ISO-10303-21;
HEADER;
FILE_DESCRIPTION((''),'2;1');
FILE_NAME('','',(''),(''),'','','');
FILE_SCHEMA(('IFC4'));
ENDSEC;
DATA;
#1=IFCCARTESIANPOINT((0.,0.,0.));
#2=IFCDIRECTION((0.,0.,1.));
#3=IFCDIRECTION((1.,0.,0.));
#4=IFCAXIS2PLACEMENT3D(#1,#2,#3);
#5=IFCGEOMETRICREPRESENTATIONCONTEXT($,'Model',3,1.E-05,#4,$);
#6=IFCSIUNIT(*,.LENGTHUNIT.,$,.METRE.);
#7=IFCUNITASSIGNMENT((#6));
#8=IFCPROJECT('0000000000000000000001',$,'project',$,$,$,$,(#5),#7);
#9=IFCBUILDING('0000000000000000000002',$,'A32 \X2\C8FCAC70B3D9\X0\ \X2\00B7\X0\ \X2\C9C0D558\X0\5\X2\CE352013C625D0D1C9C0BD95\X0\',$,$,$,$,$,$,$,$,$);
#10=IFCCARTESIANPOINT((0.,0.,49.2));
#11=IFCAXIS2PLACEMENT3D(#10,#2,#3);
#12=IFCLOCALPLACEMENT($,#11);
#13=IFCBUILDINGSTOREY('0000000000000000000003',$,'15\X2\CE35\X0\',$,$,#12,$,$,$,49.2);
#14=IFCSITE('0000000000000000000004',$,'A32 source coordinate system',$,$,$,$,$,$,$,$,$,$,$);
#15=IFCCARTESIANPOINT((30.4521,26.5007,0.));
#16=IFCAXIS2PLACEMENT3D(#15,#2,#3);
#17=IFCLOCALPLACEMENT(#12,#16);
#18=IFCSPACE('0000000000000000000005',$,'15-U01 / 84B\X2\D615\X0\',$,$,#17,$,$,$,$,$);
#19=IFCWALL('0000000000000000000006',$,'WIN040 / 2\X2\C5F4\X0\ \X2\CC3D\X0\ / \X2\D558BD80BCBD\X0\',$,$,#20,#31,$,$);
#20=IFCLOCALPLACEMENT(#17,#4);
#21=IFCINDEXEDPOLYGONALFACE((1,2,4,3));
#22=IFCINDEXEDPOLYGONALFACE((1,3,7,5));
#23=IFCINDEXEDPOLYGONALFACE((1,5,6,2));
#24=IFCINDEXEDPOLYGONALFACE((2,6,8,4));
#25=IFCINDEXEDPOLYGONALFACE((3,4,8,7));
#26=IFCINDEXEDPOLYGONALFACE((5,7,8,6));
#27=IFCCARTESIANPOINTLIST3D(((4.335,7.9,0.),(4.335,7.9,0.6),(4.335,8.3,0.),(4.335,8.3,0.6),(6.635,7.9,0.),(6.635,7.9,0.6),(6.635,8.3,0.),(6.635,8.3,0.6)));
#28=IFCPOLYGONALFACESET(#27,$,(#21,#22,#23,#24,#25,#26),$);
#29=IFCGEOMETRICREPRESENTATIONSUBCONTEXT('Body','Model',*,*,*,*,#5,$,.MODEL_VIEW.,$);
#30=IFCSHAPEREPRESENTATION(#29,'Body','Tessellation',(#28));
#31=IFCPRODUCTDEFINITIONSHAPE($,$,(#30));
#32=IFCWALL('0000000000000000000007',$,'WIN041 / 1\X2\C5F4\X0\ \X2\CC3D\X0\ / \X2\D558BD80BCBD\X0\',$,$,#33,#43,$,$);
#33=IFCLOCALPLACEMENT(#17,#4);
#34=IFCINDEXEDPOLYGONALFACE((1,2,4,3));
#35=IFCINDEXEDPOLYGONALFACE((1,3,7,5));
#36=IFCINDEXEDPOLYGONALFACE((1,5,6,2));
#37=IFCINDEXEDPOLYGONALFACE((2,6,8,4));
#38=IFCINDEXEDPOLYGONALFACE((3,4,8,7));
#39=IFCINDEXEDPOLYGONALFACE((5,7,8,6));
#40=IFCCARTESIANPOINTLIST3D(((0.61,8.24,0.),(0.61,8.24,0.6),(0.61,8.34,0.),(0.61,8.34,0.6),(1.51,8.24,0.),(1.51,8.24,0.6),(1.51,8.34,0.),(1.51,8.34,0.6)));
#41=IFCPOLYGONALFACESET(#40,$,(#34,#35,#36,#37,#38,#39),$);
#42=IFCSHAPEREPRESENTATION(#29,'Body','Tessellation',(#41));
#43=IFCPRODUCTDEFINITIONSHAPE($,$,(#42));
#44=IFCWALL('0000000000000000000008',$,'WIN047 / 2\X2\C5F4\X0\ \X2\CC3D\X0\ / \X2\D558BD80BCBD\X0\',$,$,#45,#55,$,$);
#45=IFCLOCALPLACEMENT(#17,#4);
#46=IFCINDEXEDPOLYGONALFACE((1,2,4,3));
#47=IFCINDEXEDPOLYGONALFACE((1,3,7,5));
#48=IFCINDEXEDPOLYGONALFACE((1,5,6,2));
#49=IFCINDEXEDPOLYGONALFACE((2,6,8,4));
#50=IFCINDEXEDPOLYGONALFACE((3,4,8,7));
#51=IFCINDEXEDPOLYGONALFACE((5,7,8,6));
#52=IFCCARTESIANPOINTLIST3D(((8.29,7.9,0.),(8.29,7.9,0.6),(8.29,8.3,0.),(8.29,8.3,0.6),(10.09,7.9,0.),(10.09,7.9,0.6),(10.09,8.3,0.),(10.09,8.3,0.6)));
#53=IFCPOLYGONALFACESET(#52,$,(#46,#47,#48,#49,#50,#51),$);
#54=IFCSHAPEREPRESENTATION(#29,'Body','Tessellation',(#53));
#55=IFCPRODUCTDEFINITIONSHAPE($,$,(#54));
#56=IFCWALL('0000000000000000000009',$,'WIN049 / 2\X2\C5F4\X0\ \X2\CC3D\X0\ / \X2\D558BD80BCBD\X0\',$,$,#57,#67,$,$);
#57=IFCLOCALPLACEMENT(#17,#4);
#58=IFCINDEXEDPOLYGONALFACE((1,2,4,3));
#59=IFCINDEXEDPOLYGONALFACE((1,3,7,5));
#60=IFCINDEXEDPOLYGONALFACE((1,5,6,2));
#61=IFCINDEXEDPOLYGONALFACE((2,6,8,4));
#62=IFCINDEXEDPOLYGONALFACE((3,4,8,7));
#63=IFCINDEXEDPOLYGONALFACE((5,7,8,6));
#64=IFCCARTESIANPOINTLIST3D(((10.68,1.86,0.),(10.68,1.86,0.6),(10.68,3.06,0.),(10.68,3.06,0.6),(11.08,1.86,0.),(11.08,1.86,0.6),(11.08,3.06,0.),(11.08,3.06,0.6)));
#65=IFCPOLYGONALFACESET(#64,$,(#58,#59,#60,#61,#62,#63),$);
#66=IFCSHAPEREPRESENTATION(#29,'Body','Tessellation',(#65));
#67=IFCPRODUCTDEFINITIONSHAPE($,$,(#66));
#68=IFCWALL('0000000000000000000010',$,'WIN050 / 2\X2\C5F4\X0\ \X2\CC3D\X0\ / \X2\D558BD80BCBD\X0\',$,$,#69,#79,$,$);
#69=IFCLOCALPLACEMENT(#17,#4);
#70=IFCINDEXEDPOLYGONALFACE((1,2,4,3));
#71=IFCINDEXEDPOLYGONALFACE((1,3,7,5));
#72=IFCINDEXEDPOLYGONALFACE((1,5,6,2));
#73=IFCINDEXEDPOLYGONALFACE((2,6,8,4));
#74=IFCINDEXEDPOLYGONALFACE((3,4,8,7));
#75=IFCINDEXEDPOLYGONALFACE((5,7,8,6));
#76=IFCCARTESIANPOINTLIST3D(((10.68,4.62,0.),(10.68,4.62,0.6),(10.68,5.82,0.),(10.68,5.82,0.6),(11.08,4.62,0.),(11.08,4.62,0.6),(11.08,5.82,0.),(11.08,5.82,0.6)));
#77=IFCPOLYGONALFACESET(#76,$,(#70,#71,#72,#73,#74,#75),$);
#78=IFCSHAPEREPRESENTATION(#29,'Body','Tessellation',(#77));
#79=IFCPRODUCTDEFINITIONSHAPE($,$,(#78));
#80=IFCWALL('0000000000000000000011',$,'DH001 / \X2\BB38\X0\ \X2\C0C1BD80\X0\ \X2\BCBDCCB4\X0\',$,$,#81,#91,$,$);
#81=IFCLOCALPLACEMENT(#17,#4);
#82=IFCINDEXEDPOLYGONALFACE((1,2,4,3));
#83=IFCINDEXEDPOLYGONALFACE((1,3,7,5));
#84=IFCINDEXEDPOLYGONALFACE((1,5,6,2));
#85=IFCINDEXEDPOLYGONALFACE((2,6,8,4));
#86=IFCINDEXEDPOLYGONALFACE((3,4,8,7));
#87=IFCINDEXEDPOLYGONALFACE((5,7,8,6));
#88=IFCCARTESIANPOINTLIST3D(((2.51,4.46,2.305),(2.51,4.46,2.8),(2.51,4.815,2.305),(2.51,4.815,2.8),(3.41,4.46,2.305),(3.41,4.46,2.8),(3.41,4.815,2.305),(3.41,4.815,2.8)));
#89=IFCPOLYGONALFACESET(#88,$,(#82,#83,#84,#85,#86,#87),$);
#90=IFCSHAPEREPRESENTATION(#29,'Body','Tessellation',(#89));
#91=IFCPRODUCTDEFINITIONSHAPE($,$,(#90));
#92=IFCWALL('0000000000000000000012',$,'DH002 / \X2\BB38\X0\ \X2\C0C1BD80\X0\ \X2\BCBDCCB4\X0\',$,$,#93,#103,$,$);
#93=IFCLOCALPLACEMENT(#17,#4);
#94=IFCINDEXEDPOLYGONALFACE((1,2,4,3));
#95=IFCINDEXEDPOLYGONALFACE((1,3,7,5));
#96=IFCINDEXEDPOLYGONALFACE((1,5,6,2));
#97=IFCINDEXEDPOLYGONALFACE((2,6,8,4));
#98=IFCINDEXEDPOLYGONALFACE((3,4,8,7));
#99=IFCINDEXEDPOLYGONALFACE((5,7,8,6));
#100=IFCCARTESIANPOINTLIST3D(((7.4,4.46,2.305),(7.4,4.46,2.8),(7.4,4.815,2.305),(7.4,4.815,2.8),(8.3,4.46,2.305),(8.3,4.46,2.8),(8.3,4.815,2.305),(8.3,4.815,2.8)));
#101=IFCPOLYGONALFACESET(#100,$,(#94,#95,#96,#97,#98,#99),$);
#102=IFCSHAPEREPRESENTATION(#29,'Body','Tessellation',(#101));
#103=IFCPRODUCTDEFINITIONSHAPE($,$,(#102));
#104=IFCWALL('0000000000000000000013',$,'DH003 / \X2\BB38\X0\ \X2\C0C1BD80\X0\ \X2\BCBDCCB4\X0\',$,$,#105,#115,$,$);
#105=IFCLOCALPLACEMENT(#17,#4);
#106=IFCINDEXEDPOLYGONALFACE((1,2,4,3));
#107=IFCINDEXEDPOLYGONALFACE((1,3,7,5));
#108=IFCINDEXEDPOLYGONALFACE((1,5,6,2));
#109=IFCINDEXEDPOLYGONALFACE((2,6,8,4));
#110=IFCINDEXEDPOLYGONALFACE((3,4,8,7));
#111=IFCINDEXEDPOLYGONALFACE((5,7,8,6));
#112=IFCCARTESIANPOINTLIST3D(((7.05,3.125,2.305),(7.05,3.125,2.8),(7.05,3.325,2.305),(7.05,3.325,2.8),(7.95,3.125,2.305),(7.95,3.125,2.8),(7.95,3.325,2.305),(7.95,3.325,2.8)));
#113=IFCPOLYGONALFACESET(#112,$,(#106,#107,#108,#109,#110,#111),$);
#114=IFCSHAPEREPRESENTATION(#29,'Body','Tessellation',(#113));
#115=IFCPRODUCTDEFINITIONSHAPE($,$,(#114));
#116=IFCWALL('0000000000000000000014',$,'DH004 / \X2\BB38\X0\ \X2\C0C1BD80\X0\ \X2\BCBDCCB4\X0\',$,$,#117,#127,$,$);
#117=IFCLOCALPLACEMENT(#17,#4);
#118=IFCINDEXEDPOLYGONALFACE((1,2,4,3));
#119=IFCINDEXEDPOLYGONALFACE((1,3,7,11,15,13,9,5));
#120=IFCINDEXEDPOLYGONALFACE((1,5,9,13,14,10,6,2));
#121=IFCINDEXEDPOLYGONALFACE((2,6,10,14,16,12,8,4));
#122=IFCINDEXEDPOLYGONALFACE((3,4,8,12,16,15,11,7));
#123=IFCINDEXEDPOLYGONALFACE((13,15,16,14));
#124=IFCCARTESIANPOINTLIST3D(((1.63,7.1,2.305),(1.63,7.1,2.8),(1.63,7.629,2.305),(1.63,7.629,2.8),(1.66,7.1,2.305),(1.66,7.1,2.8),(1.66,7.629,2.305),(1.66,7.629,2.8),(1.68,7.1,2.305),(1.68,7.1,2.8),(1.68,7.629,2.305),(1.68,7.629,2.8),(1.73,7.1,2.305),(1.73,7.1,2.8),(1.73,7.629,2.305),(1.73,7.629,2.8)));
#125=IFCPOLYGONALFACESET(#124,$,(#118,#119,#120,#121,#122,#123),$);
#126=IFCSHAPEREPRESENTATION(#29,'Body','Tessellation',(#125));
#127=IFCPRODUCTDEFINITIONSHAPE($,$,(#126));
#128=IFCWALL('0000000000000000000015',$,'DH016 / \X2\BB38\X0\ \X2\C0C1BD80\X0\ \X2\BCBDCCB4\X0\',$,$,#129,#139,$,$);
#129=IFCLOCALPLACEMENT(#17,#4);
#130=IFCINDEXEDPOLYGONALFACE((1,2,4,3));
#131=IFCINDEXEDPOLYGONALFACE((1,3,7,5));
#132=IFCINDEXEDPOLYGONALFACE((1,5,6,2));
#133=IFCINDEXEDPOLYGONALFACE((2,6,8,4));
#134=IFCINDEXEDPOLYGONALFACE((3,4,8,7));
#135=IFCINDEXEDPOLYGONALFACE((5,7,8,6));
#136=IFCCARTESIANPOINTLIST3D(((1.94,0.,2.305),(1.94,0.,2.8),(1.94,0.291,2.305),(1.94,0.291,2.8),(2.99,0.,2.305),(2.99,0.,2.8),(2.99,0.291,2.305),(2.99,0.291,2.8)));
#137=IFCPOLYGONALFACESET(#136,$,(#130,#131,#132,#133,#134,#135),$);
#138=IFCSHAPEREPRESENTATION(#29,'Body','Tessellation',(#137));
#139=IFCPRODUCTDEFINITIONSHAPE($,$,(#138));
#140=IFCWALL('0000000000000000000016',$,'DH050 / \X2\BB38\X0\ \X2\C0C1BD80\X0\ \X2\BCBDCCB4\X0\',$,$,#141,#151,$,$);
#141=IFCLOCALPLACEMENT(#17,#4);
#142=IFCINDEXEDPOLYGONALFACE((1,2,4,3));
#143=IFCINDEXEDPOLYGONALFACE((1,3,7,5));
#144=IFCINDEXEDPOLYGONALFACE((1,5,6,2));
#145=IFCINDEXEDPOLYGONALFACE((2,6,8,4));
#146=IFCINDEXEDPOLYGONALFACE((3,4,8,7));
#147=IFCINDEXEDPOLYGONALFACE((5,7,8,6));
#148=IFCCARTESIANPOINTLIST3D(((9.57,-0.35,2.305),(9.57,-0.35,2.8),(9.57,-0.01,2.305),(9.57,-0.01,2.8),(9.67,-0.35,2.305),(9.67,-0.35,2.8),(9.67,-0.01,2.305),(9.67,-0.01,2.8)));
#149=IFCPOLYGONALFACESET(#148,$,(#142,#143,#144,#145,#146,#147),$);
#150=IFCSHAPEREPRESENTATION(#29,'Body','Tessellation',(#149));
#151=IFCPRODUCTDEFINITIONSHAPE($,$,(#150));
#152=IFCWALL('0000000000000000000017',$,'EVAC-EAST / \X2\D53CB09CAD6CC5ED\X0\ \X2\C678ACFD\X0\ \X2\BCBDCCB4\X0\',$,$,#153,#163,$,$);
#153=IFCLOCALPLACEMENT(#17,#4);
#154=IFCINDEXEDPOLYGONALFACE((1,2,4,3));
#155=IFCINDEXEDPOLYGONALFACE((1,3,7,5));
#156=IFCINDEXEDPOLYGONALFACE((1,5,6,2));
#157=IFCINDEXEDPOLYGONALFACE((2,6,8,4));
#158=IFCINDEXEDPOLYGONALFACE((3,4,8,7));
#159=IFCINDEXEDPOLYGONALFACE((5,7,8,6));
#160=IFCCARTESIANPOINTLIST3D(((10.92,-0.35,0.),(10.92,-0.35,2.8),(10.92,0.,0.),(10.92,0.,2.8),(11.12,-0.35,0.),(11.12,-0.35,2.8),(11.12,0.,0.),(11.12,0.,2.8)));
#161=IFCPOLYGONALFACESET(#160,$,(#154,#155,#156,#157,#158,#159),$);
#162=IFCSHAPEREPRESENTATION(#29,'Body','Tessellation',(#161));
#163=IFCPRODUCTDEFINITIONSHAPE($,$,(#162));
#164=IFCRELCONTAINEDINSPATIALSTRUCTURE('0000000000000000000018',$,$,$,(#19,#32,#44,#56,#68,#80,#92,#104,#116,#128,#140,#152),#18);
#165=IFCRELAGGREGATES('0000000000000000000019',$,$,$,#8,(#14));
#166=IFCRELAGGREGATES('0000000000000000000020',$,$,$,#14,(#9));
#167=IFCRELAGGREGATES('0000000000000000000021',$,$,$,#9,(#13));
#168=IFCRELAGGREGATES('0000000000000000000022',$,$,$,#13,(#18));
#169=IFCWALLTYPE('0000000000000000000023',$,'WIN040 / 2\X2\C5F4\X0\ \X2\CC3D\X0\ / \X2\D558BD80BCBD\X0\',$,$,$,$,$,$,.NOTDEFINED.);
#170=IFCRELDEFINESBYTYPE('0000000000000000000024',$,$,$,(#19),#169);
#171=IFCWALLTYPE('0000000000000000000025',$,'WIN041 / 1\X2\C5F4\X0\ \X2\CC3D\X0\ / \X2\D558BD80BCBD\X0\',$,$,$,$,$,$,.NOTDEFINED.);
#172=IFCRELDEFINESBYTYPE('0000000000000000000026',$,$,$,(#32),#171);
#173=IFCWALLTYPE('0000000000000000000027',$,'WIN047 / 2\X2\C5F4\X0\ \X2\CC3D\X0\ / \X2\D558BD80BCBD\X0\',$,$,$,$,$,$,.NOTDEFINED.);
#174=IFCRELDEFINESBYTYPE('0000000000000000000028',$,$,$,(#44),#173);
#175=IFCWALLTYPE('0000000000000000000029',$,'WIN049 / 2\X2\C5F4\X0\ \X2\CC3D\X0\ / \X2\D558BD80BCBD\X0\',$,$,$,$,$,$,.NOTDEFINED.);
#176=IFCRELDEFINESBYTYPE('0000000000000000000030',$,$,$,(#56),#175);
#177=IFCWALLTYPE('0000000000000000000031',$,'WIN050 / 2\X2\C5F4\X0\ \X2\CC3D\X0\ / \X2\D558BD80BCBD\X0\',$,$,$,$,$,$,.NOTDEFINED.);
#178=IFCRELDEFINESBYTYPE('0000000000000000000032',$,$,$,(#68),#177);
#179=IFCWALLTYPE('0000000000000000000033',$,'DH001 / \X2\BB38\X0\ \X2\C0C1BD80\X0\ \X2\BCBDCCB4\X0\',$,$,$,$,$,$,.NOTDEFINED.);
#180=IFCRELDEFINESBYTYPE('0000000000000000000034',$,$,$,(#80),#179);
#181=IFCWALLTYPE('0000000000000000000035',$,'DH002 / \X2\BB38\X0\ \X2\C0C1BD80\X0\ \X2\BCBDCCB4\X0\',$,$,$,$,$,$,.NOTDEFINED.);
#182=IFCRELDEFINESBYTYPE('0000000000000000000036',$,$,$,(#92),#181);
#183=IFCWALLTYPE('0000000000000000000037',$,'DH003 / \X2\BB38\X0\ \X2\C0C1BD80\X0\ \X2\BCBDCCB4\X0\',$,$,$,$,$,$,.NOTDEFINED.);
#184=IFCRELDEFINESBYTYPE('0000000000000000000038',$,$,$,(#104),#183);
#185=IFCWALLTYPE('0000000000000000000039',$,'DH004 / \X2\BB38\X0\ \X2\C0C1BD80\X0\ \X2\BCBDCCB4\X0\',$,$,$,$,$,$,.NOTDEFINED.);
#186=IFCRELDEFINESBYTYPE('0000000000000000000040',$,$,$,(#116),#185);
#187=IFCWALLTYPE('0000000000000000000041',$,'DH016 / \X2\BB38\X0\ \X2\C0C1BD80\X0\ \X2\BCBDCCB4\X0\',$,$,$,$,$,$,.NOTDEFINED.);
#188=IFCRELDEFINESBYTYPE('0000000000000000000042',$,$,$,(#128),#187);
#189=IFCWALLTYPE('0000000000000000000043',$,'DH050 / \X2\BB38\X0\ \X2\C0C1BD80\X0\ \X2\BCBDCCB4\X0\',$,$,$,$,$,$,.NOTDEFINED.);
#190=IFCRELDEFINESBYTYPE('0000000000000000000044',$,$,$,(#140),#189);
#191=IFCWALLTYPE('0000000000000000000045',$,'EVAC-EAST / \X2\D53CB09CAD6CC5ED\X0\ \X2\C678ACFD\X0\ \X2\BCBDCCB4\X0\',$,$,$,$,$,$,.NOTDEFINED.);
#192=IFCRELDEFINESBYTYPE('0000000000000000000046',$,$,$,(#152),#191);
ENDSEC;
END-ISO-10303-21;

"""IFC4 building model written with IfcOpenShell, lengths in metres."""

from ifc_helpers import new_model, si_unit, frame, origin, origin_with_axes, place, context, subcontext, project, spatial, polyline, outline, extrude, source, transform, mapped, type_object, type_shapes, element, save


model = new_model("IFC4")

# Units and contexts
model_context = context("Model", 3, precision=1e-05, world=origin_with_axes())
body_context = subcontext(model_context, "Body", "Model", "MODEL_VIEW")
ifc_project = project(units=[si_unit("LENGTHUNIT", "METRE")], contexts=[model_context])

# Site, building, storey, space
site = spatial("IfcSite", under=ifc_project, Name="A32 source coordinate system")
building = spatial("IfcBuilding", under=site, Name="A32 주거동 · 지하5층–옥탑지붕")
storey_placement = place(None, frame((0.0, 0.0, 49.2), z_axis=(0.0, 0.0, 1.0), x_axis=(1.0, 0.0, 0.0)))
storey = spatial("IfcBuildingStorey", under=building, at=storey_placement, Name="15층", Elevation=49.2)
space_placement = place(storey_placement, frame((30.4521, 26.5007, 0.0), z_axis=(0.0, 0.0, 1.0), x_axis=(1.0, 0.0, 0.0)))
space = spatial("IfcSpace", under=storey, at=space_placement, Name="15-U01 / 84B형")

# Walls
wall_type_1 = type_object("IfcWallType", Name="WIN040 / 2열 창 / 하부벽", PredefinedType="NOTDEFINED")
shared_shape_1 = source(origin(), body_context, "Body", "SweptSolid", [
    extrude(outline(polyline([(4.335, 8.3), (6.635, 8.3), (6.635, 7.9), (4.335, 7.9), (4.335, 8.3)])), origin(), (0.0, 0.0, 1.0), 0.6),
])
type_shapes(wall_type_1, [shared_shape_1])
wall_1_placement = place(space_placement, origin_with_axes())
element("IfcWall", 1, at=wall_1_placement, inside=space, type_object=wall_type_1, Name="WIN040 / 2열 창 / 하부벽", context=body_context, shape_type="MappedRepresentation", body=[
    mapped(shared_shape_1, transform((0.0, 0.0, 0.0), scale=1.0)),
])
wall_type_2 = type_object("IfcWallType", Name="WIN041 / 1열 창 / 하부벽", PredefinedType="NOTDEFINED")
shared_shape_2 = source(origin(), body_context, "Body", "SweptSolid", [
    extrude(outline(polyline([(0.61, 8.34), (1.51, 8.34), (1.51, 8.24), (0.61, 8.24), (0.61, 8.34)])), origin(), (0.0, 0.0, 1.0), 0.6),
])
type_shapes(wall_type_2, [shared_shape_2])
wall_2_placement = place(space_placement, origin_with_axes())
element("IfcWall", 2, at=wall_2_placement, inside=space, type_object=wall_type_2, Name="WIN041 / 1열 창 / 하부벽", context=body_context, shape_type="MappedRepresentation", body=[
    mapped(shared_shape_2, transform((0.0, 0.0, 0.0), scale=1.0)),
])
wall_type_3 = type_object("IfcWallType", Name="WIN047 / 2열 창 / 하부벽", PredefinedType="NOTDEFINED")
shared_shape_3 = source(origin(), body_context, "Body", "SweptSolid", [
    extrude(outline(polyline([(8.29, 8.3), (10.09, 8.3), (10.09, 7.9), (8.29, 7.9), (8.29, 8.3)])), origin(), (0.0, 0.0, 1.0), 0.6),
])
type_shapes(wall_type_3, [shared_shape_3])
wall_3_placement = place(space_placement, origin_with_axes())
element("IfcWall", 3, at=wall_3_placement, inside=space, type_object=wall_type_3, Name="WIN047 / 2열 창 / 하부벽", context=body_context, shape_type="MappedRepresentation", body=[
    mapped(shared_shape_3, transform((0.0, 0.0, 0.0), scale=1.0)),
])
wall_type_4 = type_object("IfcWallType", Name="WIN049 / 2열 창 / 하부벽", PredefinedType="NOTDEFINED")
shared_shape_4 = source(origin(), body_context, "Body", "SweptSolid", [
    extrude(outline(polyline([(10.68, 3.06), (11.08, 3.06), (11.08, 1.86), (10.68, 1.86), (10.68, 3.06)])), origin(), (0.0, 0.0, 1.0), 0.6),
])
type_shapes(wall_type_4, [shared_shape_4])
wall_4_placement = place(space_placement, origin_with_axes())
element("IfcWall", 4, at=wall_4_placement, inside=space, type_object=wall_type_4, Name="WIN049 / 2열 창 / 하부벽", context=body_context, shape_type="MappedRepresentation", body=[
    mapped(shared_shape_4, transform((0.0, 0.0, 0.0), scale=1.0)),
])
wall_type_5 = type_object("IfcWallType", Name="WIN050 / 2열 창 / 하부벽", PredefinedType="NOTDEFINED")
shared_shape_5 = source(origin(), body_context, "Body", "SweptSolid", [
    extrude(outline(polyline([(10.68, 5.82), (11.08, 5.82), (11.08, 4.62), (10.68, 4.62), (10.68, 5.82)])), origin(), (0.0, 0.0, 1.0), 0.6),
])
type_shapes(wall_type_5, [shared_shape_5])
wall_5_placement = place(space_placement, origin_with_axes())
element("IfcWall", 5, at=wall_5_placement, inside=space, type_object=wall_type_5, Name="WIN050 / 2열 창 / 하부벽", context=body_context, shape_type="MappedRepresentation", body=[
    mapped(shared_shape_5, transform((0.0, 0.0, 0.0), scale=1.0)),
])
wall_type_6 = type_object("IfcWallType", Name="DH001 / 문 상부 벽체", PredefinedType="NOTDEFINED")
shared_shape_6 = source(origin(), body_context, "Body", "SweptSolid", [
    extrude(outline(polyline([(3.41, 4.815), (3.41, 4.46), (2.51, 4.46), (2.51, 4.815), (3.41, 4.815)])), frame((0.0, 0.0, 2.305)), (0.0, 0.0, 1.0), 0.495),
])
type_shapes(wall_type_6, [shared_shape_6])
wall_6_placement = place(space_placement, origin_with_axes())
element("IfcWall", 6, at=wall_6_placement, inside=space, type_object=wall_type_6, Name="DH001 / 문 상부 벽체", context=body_context, shape_type="MappedRepresentation", body=[
    mapped(shared_shape_6, transform((0.0, 0.0, 0.0), scale=1.0)),
])
wall_type_7 = type_object("IfcWallType", Name="DH002 / 문 상부 벽체", PredefinedType="NOTDEFINED")
shared_shape_7 = source(origin(), body_context, "Body", "SweptSolid", [
    extrude(outline(polyline([(8.3, 4.815), (8.3, 4.46), (7.4, 4.46), (7.4, 4.815), (8.3, 4.815)])), frame((0.0, 0.0, 2.305)), (0.0, 0.0, 1.0), 0.495),
])
type_shapes(wall_type_7, [shared_shape_7])
wall_7_placement = place(space_placement, origin_with_axes())
element("IfcWall", 7, at=wall_7_placement, inside=space, type_object=wall_type_7, Name="DH002 / 문 상부 벽체", context=body_context, shape_type="MappedRepresentation", body=[
    mapped(shared_shape_7, transform((0.0, 0.0, 0.0), scale=1.0)),
])
wall_type_8 = type_object("IfcWallType", Name="DH003 / 문 상부 벽체", PredefinedType="NOTDEFINED")
shared_shape_8 = source(origin(), body_context, "Body", "SweptSolid", [
    extrude(outline(polyline([(7.95, 3.325), (7.95, 3.125), (7.05, 3.125), (7.05, 3.325), (7.95, 3.325)])), frame((0.0, 0.0, 2.305)), (0.0, 0.0, 1.0), 0.495),
])
type_shapes(wall_type_8, [shared_shape_8])
wall_8_placement = place(space_placement, origin_with_axes())
element("IfcWall", 8, at=wall_8_placement, inside=space, type_object=wall_type_8, Name="DH003 / 문 상부 벽체", context=body_context, shape_type="MappedRepresentation", body=[
    mapped(shared_shape_8, transform((0.0, 0.0, 0.0), scale=1.0)),
])
wall_type_9 = type_object("IfcWallType", Name="DH004 / 문 상부 벽체", PredefinedType="NOTDEFINED")
shared_shape_9 = source(origin(), body_context, "Body", "SweptSolid", [
    extrude(outline(polyline([(1.66, 7.1), (1.63, 7.1), (1.63, 7.629), (1.66, 7.629), (1.68, 7.629), (1.73, 7.629), (1.73, 7.1), (1.68, 7.1), (1.66, 7.1)])), frame((0.0, 0.0, 2.305)), (0.0, 0.0, 1.0), 0.495),
])
type_shapes(wall_type_9, [shared_shape_9])
wall_9_placement = place(space_placement, origin_with_axes())
element("IfcWall", 9, at=wall_9_placement, inside=space, type_object=wall_type_9, Name="DH004 / 문 상부 벽체", context=body_context, shape_type="MappedRepresentation", body=[
    mapped(shared_shape_9, transform((0.0, 0.0, 0.0), scale=1.0)),
])
wall_type_10 = type_object("IfcWallType", Name="DH016 / 문 상부 벽체", PredefinedType="NOTDEFINED")
shared_shape_10 = source(origin(), body_context, "Body", "SweptSolid", [
    extrude(outline(polyline([(2.99, 0.291), (2.99, 0.0), (1.94, 0.0), (1.94, 0.291), (2.99, 0.291)])), frame((0.0, 0.0, 2.305)), (0.0, 0.0, 1.0), 0.495),
])
type_shapes(wall_type_10, [shared_shape_10])
wall_10_placement = place(space_placement, origin_with_axes())
element("IfcWall", 10, at=wall_10_placement, inside=space, type_object=wall_type_10, Name="DH016 / 문 상부 벽체", context=body_context, shape_type="MappedRepresentation", body=[
    mapped(shared_shape_10, transform((0.0, 0.0, 0.0), scale=1.0)),
])
wall_type_11 = type_object("IfcWallType", Name="DH050 / 문 상부 벽체", PredefinedType="NOTDEFINED")
shared_shape_11 = source(origin(), body_context, "Body", "SweptSolid", [
    extrude(outline(polyline([(9.67, -0.01), (9.67, -0.35), (9.57, -0.35), (9.57, -0.01), (9.67, -0.01)])), frame((0.0, 0.0, 2.305)), (0.0, 0.0, 1.0), 0.495),
])
type_shapes(wall_type_11, [shared_shape_11])
wall_11_placement = place(space_placement, origin_with_axes())
element("IfcWall", 11, at=wall_11_placement, inside=space, type_object=wall_type_11, Name="DH050 / 문 상부 벽체", context=body_context, shape_type="MappedRepresentation", body=[
    mapped(shared_shape_11, transform((0.0, 0.0, 0.0), scale=1.0)),
])
wall_type_12 = type_object("IfcWallType", Name="EVAC-EAST / 피난구역 외곽 벽체", PredefinedType="NOTDEFINED")
shared_shape_12 = source(origin(), body_context, "Body", "SweptSolid", [
    extrude(outline(polyline([(10.92, 0.0), (11.12, 0.0), (11.12, -0.35), (10.92, -0.35), (10.92, 0.0)])), origin(), (0.0, 0.0, 1.0), 2.8),
])
type_shapes(wall_type_12, [shared_shape_12])
wall_12_placement = place(space_placement, origin_with_axes())
element("IfcWall", 12, at=wall_12_placement, inside=space, type_object=wall_type_12, Name="EVAC-EAST / 피난구역 외곽 벽체", context=body_context, shape_type="MappedRepresentation", body=[
    mapped(shared_shape_12, transform((0.0, 0.0, 0.0), scale=1.0)),
])

save(model, "model.ifc")
